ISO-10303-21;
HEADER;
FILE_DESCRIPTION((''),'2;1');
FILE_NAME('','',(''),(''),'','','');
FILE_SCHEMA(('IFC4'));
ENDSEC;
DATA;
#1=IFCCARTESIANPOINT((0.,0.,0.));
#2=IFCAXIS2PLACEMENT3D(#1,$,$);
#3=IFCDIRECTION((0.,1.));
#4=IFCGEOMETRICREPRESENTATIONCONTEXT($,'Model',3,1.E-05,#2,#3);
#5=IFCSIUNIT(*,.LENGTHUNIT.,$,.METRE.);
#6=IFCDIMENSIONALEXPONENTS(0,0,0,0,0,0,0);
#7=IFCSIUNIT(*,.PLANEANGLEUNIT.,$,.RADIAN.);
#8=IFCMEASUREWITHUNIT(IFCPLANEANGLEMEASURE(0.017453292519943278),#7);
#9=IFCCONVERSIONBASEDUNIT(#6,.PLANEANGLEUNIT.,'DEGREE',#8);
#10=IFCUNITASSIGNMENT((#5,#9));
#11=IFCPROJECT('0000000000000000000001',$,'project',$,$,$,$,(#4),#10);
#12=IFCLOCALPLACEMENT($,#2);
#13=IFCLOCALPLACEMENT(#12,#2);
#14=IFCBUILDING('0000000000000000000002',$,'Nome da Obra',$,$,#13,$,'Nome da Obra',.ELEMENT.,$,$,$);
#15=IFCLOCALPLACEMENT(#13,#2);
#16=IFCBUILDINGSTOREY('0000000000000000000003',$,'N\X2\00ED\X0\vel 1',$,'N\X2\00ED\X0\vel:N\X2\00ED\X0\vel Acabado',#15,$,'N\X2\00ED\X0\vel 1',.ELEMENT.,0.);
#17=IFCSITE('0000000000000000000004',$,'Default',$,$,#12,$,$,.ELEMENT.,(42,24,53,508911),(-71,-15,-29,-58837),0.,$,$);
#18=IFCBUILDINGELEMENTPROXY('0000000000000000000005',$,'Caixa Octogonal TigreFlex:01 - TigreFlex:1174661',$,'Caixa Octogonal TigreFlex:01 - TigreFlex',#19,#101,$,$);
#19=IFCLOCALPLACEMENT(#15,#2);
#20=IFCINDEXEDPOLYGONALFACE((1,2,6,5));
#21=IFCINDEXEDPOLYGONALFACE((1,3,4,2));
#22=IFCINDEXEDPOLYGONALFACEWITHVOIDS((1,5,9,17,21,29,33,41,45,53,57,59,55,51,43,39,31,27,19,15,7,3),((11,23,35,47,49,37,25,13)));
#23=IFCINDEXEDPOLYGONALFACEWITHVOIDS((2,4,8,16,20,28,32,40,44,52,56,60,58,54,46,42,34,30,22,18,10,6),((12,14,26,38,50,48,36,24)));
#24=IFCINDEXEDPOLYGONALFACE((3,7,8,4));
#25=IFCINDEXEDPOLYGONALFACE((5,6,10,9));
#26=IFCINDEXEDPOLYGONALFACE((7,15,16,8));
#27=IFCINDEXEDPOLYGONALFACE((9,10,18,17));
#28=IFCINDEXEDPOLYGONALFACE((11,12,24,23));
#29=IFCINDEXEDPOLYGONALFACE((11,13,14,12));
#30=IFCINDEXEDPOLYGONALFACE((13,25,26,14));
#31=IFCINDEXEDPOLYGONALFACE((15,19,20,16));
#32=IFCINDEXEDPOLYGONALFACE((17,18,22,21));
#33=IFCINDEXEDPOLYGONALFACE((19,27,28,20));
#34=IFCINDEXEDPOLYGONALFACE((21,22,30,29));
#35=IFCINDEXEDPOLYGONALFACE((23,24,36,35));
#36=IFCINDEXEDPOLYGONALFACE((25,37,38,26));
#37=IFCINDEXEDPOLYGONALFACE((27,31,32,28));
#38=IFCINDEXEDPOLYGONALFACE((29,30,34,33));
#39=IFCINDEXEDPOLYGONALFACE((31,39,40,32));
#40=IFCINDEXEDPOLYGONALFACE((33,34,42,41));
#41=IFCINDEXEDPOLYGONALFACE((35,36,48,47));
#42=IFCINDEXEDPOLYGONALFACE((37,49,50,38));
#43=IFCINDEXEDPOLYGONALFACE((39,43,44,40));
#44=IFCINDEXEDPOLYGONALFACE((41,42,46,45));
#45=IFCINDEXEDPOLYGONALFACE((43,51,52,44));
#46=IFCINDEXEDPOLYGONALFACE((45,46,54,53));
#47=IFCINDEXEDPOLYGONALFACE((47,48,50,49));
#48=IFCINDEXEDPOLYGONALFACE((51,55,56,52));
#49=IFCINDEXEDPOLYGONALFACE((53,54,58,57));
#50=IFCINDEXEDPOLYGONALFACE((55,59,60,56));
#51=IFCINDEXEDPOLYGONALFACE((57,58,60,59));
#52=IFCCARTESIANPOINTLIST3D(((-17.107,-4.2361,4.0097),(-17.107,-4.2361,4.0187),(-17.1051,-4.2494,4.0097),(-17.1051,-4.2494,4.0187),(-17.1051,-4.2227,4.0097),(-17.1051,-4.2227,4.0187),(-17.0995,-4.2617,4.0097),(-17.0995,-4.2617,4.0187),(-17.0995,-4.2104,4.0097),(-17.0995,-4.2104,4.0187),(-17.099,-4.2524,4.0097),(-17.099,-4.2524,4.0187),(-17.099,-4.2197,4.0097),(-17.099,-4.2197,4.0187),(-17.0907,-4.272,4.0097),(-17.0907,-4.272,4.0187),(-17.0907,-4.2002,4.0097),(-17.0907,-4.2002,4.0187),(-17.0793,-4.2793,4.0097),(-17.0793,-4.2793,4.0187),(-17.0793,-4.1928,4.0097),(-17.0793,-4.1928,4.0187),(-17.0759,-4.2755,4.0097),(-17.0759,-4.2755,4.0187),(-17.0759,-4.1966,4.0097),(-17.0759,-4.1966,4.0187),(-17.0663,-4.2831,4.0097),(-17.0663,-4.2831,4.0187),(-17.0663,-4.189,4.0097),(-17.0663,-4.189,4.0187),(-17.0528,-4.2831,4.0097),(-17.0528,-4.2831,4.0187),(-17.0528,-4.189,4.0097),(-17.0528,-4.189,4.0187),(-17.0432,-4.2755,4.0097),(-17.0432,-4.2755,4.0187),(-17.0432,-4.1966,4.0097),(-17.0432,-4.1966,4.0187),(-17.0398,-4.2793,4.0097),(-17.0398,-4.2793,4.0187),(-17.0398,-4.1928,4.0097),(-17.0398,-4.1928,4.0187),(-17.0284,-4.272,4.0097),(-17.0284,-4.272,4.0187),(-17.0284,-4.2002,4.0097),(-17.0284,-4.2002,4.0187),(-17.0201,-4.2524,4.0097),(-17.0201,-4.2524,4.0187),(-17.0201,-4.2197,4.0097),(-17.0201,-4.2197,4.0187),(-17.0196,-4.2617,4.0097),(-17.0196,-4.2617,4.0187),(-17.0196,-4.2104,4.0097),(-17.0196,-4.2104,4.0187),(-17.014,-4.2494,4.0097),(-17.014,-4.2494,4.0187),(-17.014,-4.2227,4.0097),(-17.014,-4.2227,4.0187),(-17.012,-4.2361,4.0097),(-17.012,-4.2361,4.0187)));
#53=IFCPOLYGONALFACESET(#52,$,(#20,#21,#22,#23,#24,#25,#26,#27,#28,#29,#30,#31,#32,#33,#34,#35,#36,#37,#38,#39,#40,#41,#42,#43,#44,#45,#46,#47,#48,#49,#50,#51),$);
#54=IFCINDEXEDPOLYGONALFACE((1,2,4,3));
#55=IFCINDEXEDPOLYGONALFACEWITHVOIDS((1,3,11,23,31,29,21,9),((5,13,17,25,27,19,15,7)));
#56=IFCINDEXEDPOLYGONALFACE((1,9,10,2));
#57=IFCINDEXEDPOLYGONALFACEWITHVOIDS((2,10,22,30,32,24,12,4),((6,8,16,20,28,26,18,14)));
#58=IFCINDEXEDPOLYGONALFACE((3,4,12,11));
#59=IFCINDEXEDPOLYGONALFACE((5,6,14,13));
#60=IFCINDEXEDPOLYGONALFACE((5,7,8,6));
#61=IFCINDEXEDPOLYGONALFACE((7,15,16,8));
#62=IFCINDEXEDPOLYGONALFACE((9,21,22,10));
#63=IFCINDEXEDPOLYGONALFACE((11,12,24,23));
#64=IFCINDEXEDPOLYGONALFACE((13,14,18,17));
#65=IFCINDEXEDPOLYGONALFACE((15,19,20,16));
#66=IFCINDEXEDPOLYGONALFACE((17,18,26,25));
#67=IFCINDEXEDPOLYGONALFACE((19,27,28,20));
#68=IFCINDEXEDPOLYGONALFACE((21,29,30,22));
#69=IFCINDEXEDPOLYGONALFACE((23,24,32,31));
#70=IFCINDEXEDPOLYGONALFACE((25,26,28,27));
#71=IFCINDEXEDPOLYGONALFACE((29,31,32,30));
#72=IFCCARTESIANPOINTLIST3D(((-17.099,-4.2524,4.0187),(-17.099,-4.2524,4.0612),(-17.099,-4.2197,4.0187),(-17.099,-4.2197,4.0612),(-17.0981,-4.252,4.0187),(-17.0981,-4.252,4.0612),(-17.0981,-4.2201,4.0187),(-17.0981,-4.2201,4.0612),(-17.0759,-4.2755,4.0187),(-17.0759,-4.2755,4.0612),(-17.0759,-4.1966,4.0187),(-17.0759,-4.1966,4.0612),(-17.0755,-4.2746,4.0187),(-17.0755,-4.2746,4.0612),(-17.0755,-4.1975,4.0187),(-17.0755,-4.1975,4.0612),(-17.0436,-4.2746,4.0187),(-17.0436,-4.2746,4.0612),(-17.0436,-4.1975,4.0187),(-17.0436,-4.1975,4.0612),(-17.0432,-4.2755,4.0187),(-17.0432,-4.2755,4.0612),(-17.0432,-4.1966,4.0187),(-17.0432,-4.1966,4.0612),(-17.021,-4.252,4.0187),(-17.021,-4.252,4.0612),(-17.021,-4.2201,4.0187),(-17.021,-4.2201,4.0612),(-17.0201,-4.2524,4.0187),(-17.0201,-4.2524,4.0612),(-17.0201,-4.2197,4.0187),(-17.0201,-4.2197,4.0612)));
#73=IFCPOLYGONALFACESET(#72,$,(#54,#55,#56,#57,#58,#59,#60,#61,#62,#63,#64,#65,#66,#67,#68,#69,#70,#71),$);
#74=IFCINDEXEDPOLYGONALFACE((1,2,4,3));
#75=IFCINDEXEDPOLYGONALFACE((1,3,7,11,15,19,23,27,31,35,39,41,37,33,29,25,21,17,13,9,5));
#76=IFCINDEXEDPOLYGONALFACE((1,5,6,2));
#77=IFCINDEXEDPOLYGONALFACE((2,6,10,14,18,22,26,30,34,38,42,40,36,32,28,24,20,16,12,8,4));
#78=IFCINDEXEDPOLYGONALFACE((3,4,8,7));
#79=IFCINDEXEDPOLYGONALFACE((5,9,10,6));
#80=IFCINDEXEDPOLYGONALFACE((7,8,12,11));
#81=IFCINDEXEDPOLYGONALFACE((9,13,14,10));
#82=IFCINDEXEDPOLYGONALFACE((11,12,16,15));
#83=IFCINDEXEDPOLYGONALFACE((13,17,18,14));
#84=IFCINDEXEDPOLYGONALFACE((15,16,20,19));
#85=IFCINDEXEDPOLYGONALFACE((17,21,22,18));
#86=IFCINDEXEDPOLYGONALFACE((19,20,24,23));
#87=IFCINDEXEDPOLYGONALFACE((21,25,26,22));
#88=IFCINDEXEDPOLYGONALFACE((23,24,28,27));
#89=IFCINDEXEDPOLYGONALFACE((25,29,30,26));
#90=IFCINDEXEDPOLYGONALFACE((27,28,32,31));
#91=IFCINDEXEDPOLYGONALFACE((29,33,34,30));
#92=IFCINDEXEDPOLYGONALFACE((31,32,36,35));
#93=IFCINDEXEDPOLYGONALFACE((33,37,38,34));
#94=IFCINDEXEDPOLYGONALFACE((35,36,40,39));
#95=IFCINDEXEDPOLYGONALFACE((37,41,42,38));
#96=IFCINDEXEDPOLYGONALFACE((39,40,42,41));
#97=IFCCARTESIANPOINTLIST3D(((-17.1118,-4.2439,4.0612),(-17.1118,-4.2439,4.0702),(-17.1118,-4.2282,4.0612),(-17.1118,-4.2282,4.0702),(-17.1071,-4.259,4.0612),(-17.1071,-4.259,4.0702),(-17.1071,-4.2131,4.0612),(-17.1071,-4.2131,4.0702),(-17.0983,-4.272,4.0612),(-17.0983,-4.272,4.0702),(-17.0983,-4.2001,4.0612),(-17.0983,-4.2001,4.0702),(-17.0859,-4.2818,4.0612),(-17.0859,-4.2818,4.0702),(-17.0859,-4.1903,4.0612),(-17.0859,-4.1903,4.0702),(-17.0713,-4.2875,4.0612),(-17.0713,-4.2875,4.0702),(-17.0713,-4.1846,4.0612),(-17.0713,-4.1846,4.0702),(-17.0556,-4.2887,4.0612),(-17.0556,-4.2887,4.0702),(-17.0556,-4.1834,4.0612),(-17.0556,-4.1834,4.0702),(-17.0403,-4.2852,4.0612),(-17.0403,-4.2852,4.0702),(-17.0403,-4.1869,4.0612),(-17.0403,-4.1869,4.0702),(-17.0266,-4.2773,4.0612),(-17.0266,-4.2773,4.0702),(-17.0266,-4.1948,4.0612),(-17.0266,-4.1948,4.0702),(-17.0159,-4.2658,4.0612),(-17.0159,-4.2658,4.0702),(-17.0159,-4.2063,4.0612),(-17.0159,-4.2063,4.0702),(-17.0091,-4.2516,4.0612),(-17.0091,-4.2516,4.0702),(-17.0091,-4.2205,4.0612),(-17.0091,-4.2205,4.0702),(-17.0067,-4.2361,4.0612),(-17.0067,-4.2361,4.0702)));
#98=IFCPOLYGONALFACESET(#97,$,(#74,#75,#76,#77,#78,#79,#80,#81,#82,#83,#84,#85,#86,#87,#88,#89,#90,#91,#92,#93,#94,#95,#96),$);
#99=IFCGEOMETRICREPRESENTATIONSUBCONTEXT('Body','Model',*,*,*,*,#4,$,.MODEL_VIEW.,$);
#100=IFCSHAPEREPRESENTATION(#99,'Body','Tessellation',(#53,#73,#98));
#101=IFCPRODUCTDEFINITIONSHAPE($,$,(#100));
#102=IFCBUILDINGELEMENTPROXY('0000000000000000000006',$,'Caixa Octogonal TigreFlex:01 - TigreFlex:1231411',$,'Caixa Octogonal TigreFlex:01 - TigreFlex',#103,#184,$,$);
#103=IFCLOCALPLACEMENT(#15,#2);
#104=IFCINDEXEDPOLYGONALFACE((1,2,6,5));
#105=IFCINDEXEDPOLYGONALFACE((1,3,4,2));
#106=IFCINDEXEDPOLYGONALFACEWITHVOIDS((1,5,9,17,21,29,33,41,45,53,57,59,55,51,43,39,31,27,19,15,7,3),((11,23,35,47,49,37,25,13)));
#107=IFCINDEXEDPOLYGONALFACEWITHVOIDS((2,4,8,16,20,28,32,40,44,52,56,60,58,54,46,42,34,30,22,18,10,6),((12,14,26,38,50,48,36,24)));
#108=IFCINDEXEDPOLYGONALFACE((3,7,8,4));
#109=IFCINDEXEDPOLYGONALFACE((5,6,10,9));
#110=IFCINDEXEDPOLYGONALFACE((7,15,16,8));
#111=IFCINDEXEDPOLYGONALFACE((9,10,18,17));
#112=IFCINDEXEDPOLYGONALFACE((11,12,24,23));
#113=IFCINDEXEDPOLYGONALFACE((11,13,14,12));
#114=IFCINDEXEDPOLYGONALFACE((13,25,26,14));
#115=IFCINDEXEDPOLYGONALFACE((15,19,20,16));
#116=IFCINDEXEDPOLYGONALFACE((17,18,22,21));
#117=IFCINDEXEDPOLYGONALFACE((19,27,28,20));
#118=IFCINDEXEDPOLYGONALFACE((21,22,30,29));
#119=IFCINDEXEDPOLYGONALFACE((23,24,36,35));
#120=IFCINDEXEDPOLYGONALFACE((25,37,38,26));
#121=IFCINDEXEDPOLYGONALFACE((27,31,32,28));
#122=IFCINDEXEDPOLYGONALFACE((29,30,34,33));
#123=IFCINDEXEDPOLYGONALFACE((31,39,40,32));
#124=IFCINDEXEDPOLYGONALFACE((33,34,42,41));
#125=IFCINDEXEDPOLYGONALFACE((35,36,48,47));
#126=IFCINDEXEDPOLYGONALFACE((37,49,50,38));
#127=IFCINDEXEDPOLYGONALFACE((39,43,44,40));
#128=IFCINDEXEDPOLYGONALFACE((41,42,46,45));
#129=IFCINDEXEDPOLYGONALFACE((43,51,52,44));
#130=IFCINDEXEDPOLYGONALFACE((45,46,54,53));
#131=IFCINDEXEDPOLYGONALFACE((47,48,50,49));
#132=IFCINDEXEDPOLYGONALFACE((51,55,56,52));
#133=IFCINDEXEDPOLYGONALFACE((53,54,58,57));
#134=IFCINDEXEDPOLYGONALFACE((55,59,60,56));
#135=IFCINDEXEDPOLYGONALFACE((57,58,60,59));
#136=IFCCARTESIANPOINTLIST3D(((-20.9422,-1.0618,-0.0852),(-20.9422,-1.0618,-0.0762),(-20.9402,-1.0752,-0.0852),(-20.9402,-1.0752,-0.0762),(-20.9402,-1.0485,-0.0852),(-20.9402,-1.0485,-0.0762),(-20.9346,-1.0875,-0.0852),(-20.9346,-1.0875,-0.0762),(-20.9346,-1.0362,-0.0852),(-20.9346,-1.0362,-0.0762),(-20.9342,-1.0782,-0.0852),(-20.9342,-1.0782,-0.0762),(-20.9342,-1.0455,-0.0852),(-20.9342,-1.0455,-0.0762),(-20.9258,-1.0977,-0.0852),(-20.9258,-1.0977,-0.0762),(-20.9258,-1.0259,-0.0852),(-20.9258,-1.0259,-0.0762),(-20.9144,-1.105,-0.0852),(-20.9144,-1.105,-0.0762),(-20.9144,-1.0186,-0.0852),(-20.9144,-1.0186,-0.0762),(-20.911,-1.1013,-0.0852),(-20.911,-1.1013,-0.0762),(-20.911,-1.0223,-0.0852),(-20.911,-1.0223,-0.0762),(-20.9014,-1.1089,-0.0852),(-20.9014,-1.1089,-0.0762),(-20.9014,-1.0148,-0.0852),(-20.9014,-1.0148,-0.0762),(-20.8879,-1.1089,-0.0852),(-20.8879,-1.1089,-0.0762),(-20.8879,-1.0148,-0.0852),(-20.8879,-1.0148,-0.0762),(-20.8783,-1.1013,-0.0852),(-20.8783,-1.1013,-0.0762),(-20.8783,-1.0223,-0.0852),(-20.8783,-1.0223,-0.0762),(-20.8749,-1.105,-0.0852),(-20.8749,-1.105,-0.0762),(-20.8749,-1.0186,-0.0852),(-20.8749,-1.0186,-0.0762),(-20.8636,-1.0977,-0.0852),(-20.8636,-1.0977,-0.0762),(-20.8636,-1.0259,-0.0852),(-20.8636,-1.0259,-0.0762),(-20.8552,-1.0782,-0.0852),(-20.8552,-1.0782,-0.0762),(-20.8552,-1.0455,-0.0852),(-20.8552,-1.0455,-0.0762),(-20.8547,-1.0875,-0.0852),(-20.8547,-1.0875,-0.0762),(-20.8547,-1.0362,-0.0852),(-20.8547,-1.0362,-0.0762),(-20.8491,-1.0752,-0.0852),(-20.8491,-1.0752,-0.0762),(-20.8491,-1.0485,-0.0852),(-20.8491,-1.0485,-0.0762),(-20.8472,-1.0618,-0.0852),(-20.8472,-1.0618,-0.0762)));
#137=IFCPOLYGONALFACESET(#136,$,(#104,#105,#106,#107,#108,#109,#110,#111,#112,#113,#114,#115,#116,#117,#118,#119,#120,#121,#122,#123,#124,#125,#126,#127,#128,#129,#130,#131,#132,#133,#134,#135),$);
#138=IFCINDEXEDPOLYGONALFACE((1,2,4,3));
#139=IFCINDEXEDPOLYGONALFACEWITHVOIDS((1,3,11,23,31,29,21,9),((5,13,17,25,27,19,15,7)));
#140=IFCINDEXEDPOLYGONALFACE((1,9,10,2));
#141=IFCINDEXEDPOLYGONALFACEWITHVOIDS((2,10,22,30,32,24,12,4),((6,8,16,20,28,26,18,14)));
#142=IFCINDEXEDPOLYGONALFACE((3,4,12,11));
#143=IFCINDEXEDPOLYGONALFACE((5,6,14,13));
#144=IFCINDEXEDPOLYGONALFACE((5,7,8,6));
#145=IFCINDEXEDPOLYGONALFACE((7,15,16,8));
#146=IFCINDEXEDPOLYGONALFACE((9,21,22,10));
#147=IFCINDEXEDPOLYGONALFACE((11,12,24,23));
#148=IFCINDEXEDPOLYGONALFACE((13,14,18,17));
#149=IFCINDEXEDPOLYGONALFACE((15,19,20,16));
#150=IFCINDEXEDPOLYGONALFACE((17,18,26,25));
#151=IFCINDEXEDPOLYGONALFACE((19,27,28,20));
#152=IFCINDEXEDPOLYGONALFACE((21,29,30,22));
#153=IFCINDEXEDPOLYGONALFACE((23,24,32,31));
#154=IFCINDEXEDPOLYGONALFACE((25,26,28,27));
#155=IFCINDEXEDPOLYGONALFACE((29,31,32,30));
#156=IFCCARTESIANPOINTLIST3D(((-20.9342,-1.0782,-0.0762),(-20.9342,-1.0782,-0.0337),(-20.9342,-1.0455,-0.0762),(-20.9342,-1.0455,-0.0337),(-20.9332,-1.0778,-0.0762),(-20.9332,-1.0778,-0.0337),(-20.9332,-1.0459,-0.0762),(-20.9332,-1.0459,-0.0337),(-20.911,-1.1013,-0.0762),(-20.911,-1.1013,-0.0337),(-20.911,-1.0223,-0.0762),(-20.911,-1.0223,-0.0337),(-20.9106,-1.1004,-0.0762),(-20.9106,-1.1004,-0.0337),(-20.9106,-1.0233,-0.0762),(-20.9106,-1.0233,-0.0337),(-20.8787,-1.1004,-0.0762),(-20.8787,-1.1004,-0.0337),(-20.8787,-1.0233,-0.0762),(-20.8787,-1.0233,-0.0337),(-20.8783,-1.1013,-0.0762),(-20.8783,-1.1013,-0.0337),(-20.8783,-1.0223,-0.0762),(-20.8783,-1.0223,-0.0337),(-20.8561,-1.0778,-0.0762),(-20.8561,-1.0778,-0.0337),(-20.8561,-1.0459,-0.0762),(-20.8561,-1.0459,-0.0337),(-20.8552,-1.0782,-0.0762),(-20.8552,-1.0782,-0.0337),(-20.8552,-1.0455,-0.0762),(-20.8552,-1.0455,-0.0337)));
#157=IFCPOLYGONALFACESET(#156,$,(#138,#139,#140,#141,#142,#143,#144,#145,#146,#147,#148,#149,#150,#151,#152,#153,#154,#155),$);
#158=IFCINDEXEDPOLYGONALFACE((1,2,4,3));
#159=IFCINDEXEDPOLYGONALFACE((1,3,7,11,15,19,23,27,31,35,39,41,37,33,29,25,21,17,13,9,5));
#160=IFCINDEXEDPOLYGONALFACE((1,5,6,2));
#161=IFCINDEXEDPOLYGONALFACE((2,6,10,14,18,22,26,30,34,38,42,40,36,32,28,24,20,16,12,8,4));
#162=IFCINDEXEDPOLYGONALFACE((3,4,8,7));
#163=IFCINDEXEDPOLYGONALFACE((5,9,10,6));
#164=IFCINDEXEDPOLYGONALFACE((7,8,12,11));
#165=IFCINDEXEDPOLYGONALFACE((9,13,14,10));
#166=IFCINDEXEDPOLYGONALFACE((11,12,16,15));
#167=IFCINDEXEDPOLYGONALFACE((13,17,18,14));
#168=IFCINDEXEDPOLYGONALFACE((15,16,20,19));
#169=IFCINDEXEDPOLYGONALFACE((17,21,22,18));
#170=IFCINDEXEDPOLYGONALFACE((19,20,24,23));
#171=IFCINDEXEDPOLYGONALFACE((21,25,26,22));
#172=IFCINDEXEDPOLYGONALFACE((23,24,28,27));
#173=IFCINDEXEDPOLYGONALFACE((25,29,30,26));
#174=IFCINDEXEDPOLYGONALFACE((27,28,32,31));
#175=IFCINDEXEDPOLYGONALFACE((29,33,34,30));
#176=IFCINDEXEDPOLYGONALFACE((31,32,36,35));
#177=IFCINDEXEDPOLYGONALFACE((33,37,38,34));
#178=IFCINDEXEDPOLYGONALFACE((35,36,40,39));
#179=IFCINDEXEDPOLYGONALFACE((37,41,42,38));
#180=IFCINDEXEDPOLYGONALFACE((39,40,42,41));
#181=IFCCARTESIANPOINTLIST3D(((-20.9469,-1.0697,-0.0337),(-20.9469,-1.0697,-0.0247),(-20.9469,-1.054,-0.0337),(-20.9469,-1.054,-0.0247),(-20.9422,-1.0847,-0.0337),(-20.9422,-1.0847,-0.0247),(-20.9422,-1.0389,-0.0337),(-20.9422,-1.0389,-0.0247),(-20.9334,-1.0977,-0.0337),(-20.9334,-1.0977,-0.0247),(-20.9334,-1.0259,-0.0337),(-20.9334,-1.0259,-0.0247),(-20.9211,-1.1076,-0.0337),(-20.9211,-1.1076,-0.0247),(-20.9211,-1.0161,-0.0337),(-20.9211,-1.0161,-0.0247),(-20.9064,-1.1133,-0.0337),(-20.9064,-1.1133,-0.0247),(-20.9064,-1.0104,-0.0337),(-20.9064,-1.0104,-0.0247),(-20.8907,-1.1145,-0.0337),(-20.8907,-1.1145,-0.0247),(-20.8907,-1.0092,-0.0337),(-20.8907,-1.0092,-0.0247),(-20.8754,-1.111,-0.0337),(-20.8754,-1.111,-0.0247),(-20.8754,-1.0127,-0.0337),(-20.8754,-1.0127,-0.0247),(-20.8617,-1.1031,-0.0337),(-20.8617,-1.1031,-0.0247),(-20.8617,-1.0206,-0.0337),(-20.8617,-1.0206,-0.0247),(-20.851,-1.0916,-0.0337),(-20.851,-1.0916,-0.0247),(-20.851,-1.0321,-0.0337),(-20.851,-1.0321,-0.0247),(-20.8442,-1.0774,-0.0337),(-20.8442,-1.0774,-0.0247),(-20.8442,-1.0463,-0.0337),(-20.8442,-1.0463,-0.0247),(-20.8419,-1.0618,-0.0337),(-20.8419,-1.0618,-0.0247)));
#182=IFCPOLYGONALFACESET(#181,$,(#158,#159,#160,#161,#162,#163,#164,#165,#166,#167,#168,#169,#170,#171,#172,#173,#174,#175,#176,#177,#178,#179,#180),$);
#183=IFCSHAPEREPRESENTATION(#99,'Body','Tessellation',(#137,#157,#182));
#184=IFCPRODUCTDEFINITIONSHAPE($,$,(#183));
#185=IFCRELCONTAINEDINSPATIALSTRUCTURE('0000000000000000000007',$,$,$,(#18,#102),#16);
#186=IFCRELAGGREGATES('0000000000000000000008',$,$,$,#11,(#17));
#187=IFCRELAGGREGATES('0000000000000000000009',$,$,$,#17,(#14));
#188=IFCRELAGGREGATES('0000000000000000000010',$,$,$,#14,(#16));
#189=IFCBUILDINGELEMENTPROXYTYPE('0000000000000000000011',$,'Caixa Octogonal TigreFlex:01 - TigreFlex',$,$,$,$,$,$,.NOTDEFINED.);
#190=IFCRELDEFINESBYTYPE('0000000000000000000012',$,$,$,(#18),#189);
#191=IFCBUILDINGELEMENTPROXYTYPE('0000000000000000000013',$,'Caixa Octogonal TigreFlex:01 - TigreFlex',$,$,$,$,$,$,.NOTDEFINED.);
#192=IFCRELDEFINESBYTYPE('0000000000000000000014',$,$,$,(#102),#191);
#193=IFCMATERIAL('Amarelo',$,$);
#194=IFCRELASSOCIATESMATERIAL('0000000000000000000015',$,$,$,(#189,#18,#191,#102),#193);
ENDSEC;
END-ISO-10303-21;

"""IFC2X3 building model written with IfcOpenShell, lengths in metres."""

from ifc_helpers import new_model, entity, si_unit, converted_unit, direction, frame, frame_2d, origin, origin_2d_with_axis, place, context, subcontext, project, spatial, polyline, circle_curve, parameter, trimmed, segment, composite_curve, circle, outline, extrude, source, transform, mapped, material, type_object, type_shapes, element, save


model = new_model("IFC2X3")

# Units and contexts
model_context = context("Model", 3, precision=1e-05, world=origin(), true_north=direction((0.0, 1.0)))
body_context = subcontext(model_context, "Body", "Model", "MODEL_VIEW")
ifc_project = project(units=[si_unit("LENGTHUNIT", "METRE"), converted_unit("PLANEANGLEUNIT", "DEGREE", entity("IfcPlaneAngleMeasure", 0.017453292519943278), si_unit("PLANEANGLEUNIT", "RADIAN"), dimensions=[0, 0, 0, 0, 0, 0, 0])], contexts=[model_context])

# Site, building, storey
site_placement = place(None, origin())
site = spatial("IfcSite", under=ifc_project, at=site_placement, Name="Default", CompositionType="ELEMENT", RefLatitude=(42, 24, 53, 508911), RefLongitude=(-71, -15, -29, -58837), RefElevation=0.0)
building_placement = place(site_placement, origin())
building = spatial("IfcBuilding", under=site, at=building_placement, Name="Nome da Obra", LongName="Nome da Obra", CompositionType="ELEMENT")
storey_placement = place(building_placement, origin())
storey = spatial("IfcBuildingStorey", under=building, at=storey_placement, Name="Nível 1", ObjectType="Nível:Nível Acabado", LongName="Nível 1", CompositionType="ELEMENT", Elevation=0.0)

# Building element proxies
ifc_material_1 = material(Name="Amarelo")
building_element_proxy_type_1 = type_object("IfcBuildingElementProxyType", Name="Caixa Octogonal TigreFlex:01 - TigreFlex", PredefinedType="NOTDEFINED", material=ifc_material_1)
shared_shape_1 = source(origin(), body_context, "Body", "SweptSolid", [
    extrude(outline(composite_curve([segment(trimmed(circle_curve(origin_2d_with_axis(), 0.0475), [parameter(180.0)], [parameter(360.0)], True, "PARAMETER"), True, "CONTINUOUS"), segment(trimmed(circle_curve(origin_2d_with_axis(), 0.0475), [parameter(0.0)], [parameter(180.0)], True, "PARAMETER"), True, "CONTINUOUS")], self_intersect=False), holes=[polyline([(-0.0395, 0.0164), (-0.0164, 0.0395), (0.0164, 0.0395), (0.0395, 0.0164), (0.0395, -0.0164), (0.0164, -0.0395), (-0.0164, -0.0395), (-0.0395, -0.0164), (-0.0395, 0.0164)])]), frame((0.0, 0.0, 3.9698)), (0.0, 0.0, 1.0), 0.009),
    extrude(outline(polyline([(-0.0164, -0.0395), (0.0164, -0.0395), (0.0395, -0.0164), (0.0395, 0.0164), (0.0164, 0.0395), (-0.0164, 0.0395), (-0.0395, 0.0164), (-0.0395, -0.0164), (-0.0164, -0.0395)]), holes=[polyline([(-0.016, -0.0386), (-0.0386, -0.016), (-0.0386, 0.016), (-0.016, 0.0386), (0.016, 0.0386), (0.0386, 0.016), (0.0386, -0.016), (0.016, -0.0386), (-0.016, -0.0386)])]), frame((0.0, 0.0, 3.9788), z_axis=(0.0, 0.0, 1.0), x_axis=(0.0, -1.0, 0.0)), (0.0, 0.0, 1.0), 0.0425),
    extrude(circle(Radius=0.0528, at=frame_2d((0.0, 0.0), x_axis=(1.0, 0.0))), frame((0.0, 0.0, 4.0213)), (0.0, 0.0, 1.0), 0.009),
])
type_shapes(building_element_proxy_type_1, [shared_shape_1])
proxy_1_placement = place(storey_placement, frame((-17.0595, -4.2361, 0.04)))
element("IfcBuildingElementProxy", 1, at=proxy_1_placement, inside=storey, type_object=building_element_proxy_type_1, material=ifc_material_1, Name="Caixa Octogonal TigreFlex:01 - TigreFlex:1174661", ObjectType="Caixa Octogonal TigreFlex:01 - TigreFlex", context=body_context, shape_type="MappedRepresentation", body=[
    mapped(shared_shape_1, transform((0.0, 0.0, 0.0), scale=1.0)),
])
building_element_proxy_type_2 = type_object("IfcBuildingElementProxyType", Name="Caixa Octogonal TigreFlex:01 - TigreFlex", PredefinedType="NOTDEFINED", material=ifc_material_1)
shared_shape_2 = source(origin(), body_context, "Body", "SweptSolid", [
    extrude(outline(composite_curve([segment(trimmed(circle_curve(origin_2d_with_axis(), 0.0475), [parameter(180.0)], [parameter(360.0)], True, "PARAMETER"), True, "CONTINUOUS"), segment(trimmed(circle_curve(origin_2d_with_axis(), 0.0475), [parameter(0.0)], [parameter(180.0)], True, "PARAMETER"), True, "CONTINUOUS")], self_intersect=False), holes=[polyline([(-0.0395, 0.0164), (-0.0164, 0.0395), (0.0164, 0.0395), (0.0395, 0.0164), (0.0395, -0.0164), (0.0164, -0.0395), (-0.0164, -0.0395), (-0.0395, -0.0164), (-0.0395, 0.0164)])]), frame((0.0, 0.0, -0.0302)), (0.0, 0.0, 1.0), 0.009),
    extrude(outline(polyline([(-0.0164, -0.0395), (0.0164, -0.0395), (0.0395, -0.0164), (0.0395, 0.0164), (0.0164, 0.0395), (-0.0164, 0.0395), (-0.0395, 0.0164), (-0.0395, -0.0164), (-0.0164, -0.0395)]), holes=[polyline([(-0.016, -0.0386), (-0.0386, -0.016), (-0.0386, 0.016), (-0.016, 0.0386), (0.016, 0.0386), (0.0386, 0.016), (0.0386, -0.016), (0.016, -0.0386), (-0.016, -0.0386)])]), frame((0.0, 0.0, -0.0212), z_axis=(0.0, 0.0, 1.0), x_axis=(0.0, -1.0, 0.0)), (0.0, 0.0, 1.0), 0.0425),
    extrude(circle(Radius=0.0528, at=frame_2d((0.0, 0.0), x_axis=(1.0, 0.0))), frame((0.0, 0.0, 0.0213)), (0.0, 0.0, 1.0), 0.009),
])
type_shapes(building_element_proxy_type_2, [shared_shape_2])
for number, where, name in (
    (2, (-20.8947, -1.0618, -0.055), "Caixa Octogonal TigreFlex:01 - TigreFlex:1231411"),
):
    element("IfcBuildingElementProxy", number, at=place(storey_placement, frame(where)), inside=storey, type_object=building_element_proxy_type_2, material=ifc_material_1, Name=name, ObjectType="Caixa Octogonal TigreFlex:01 - TigreFlex", context=body_context, shape_type="MappedRepresentation", body=[
        mapped(shared_shape_2, transform((0.0, 0.0, 0.0), scale=1.0)),
    ])

save(model, "model.ifc")
